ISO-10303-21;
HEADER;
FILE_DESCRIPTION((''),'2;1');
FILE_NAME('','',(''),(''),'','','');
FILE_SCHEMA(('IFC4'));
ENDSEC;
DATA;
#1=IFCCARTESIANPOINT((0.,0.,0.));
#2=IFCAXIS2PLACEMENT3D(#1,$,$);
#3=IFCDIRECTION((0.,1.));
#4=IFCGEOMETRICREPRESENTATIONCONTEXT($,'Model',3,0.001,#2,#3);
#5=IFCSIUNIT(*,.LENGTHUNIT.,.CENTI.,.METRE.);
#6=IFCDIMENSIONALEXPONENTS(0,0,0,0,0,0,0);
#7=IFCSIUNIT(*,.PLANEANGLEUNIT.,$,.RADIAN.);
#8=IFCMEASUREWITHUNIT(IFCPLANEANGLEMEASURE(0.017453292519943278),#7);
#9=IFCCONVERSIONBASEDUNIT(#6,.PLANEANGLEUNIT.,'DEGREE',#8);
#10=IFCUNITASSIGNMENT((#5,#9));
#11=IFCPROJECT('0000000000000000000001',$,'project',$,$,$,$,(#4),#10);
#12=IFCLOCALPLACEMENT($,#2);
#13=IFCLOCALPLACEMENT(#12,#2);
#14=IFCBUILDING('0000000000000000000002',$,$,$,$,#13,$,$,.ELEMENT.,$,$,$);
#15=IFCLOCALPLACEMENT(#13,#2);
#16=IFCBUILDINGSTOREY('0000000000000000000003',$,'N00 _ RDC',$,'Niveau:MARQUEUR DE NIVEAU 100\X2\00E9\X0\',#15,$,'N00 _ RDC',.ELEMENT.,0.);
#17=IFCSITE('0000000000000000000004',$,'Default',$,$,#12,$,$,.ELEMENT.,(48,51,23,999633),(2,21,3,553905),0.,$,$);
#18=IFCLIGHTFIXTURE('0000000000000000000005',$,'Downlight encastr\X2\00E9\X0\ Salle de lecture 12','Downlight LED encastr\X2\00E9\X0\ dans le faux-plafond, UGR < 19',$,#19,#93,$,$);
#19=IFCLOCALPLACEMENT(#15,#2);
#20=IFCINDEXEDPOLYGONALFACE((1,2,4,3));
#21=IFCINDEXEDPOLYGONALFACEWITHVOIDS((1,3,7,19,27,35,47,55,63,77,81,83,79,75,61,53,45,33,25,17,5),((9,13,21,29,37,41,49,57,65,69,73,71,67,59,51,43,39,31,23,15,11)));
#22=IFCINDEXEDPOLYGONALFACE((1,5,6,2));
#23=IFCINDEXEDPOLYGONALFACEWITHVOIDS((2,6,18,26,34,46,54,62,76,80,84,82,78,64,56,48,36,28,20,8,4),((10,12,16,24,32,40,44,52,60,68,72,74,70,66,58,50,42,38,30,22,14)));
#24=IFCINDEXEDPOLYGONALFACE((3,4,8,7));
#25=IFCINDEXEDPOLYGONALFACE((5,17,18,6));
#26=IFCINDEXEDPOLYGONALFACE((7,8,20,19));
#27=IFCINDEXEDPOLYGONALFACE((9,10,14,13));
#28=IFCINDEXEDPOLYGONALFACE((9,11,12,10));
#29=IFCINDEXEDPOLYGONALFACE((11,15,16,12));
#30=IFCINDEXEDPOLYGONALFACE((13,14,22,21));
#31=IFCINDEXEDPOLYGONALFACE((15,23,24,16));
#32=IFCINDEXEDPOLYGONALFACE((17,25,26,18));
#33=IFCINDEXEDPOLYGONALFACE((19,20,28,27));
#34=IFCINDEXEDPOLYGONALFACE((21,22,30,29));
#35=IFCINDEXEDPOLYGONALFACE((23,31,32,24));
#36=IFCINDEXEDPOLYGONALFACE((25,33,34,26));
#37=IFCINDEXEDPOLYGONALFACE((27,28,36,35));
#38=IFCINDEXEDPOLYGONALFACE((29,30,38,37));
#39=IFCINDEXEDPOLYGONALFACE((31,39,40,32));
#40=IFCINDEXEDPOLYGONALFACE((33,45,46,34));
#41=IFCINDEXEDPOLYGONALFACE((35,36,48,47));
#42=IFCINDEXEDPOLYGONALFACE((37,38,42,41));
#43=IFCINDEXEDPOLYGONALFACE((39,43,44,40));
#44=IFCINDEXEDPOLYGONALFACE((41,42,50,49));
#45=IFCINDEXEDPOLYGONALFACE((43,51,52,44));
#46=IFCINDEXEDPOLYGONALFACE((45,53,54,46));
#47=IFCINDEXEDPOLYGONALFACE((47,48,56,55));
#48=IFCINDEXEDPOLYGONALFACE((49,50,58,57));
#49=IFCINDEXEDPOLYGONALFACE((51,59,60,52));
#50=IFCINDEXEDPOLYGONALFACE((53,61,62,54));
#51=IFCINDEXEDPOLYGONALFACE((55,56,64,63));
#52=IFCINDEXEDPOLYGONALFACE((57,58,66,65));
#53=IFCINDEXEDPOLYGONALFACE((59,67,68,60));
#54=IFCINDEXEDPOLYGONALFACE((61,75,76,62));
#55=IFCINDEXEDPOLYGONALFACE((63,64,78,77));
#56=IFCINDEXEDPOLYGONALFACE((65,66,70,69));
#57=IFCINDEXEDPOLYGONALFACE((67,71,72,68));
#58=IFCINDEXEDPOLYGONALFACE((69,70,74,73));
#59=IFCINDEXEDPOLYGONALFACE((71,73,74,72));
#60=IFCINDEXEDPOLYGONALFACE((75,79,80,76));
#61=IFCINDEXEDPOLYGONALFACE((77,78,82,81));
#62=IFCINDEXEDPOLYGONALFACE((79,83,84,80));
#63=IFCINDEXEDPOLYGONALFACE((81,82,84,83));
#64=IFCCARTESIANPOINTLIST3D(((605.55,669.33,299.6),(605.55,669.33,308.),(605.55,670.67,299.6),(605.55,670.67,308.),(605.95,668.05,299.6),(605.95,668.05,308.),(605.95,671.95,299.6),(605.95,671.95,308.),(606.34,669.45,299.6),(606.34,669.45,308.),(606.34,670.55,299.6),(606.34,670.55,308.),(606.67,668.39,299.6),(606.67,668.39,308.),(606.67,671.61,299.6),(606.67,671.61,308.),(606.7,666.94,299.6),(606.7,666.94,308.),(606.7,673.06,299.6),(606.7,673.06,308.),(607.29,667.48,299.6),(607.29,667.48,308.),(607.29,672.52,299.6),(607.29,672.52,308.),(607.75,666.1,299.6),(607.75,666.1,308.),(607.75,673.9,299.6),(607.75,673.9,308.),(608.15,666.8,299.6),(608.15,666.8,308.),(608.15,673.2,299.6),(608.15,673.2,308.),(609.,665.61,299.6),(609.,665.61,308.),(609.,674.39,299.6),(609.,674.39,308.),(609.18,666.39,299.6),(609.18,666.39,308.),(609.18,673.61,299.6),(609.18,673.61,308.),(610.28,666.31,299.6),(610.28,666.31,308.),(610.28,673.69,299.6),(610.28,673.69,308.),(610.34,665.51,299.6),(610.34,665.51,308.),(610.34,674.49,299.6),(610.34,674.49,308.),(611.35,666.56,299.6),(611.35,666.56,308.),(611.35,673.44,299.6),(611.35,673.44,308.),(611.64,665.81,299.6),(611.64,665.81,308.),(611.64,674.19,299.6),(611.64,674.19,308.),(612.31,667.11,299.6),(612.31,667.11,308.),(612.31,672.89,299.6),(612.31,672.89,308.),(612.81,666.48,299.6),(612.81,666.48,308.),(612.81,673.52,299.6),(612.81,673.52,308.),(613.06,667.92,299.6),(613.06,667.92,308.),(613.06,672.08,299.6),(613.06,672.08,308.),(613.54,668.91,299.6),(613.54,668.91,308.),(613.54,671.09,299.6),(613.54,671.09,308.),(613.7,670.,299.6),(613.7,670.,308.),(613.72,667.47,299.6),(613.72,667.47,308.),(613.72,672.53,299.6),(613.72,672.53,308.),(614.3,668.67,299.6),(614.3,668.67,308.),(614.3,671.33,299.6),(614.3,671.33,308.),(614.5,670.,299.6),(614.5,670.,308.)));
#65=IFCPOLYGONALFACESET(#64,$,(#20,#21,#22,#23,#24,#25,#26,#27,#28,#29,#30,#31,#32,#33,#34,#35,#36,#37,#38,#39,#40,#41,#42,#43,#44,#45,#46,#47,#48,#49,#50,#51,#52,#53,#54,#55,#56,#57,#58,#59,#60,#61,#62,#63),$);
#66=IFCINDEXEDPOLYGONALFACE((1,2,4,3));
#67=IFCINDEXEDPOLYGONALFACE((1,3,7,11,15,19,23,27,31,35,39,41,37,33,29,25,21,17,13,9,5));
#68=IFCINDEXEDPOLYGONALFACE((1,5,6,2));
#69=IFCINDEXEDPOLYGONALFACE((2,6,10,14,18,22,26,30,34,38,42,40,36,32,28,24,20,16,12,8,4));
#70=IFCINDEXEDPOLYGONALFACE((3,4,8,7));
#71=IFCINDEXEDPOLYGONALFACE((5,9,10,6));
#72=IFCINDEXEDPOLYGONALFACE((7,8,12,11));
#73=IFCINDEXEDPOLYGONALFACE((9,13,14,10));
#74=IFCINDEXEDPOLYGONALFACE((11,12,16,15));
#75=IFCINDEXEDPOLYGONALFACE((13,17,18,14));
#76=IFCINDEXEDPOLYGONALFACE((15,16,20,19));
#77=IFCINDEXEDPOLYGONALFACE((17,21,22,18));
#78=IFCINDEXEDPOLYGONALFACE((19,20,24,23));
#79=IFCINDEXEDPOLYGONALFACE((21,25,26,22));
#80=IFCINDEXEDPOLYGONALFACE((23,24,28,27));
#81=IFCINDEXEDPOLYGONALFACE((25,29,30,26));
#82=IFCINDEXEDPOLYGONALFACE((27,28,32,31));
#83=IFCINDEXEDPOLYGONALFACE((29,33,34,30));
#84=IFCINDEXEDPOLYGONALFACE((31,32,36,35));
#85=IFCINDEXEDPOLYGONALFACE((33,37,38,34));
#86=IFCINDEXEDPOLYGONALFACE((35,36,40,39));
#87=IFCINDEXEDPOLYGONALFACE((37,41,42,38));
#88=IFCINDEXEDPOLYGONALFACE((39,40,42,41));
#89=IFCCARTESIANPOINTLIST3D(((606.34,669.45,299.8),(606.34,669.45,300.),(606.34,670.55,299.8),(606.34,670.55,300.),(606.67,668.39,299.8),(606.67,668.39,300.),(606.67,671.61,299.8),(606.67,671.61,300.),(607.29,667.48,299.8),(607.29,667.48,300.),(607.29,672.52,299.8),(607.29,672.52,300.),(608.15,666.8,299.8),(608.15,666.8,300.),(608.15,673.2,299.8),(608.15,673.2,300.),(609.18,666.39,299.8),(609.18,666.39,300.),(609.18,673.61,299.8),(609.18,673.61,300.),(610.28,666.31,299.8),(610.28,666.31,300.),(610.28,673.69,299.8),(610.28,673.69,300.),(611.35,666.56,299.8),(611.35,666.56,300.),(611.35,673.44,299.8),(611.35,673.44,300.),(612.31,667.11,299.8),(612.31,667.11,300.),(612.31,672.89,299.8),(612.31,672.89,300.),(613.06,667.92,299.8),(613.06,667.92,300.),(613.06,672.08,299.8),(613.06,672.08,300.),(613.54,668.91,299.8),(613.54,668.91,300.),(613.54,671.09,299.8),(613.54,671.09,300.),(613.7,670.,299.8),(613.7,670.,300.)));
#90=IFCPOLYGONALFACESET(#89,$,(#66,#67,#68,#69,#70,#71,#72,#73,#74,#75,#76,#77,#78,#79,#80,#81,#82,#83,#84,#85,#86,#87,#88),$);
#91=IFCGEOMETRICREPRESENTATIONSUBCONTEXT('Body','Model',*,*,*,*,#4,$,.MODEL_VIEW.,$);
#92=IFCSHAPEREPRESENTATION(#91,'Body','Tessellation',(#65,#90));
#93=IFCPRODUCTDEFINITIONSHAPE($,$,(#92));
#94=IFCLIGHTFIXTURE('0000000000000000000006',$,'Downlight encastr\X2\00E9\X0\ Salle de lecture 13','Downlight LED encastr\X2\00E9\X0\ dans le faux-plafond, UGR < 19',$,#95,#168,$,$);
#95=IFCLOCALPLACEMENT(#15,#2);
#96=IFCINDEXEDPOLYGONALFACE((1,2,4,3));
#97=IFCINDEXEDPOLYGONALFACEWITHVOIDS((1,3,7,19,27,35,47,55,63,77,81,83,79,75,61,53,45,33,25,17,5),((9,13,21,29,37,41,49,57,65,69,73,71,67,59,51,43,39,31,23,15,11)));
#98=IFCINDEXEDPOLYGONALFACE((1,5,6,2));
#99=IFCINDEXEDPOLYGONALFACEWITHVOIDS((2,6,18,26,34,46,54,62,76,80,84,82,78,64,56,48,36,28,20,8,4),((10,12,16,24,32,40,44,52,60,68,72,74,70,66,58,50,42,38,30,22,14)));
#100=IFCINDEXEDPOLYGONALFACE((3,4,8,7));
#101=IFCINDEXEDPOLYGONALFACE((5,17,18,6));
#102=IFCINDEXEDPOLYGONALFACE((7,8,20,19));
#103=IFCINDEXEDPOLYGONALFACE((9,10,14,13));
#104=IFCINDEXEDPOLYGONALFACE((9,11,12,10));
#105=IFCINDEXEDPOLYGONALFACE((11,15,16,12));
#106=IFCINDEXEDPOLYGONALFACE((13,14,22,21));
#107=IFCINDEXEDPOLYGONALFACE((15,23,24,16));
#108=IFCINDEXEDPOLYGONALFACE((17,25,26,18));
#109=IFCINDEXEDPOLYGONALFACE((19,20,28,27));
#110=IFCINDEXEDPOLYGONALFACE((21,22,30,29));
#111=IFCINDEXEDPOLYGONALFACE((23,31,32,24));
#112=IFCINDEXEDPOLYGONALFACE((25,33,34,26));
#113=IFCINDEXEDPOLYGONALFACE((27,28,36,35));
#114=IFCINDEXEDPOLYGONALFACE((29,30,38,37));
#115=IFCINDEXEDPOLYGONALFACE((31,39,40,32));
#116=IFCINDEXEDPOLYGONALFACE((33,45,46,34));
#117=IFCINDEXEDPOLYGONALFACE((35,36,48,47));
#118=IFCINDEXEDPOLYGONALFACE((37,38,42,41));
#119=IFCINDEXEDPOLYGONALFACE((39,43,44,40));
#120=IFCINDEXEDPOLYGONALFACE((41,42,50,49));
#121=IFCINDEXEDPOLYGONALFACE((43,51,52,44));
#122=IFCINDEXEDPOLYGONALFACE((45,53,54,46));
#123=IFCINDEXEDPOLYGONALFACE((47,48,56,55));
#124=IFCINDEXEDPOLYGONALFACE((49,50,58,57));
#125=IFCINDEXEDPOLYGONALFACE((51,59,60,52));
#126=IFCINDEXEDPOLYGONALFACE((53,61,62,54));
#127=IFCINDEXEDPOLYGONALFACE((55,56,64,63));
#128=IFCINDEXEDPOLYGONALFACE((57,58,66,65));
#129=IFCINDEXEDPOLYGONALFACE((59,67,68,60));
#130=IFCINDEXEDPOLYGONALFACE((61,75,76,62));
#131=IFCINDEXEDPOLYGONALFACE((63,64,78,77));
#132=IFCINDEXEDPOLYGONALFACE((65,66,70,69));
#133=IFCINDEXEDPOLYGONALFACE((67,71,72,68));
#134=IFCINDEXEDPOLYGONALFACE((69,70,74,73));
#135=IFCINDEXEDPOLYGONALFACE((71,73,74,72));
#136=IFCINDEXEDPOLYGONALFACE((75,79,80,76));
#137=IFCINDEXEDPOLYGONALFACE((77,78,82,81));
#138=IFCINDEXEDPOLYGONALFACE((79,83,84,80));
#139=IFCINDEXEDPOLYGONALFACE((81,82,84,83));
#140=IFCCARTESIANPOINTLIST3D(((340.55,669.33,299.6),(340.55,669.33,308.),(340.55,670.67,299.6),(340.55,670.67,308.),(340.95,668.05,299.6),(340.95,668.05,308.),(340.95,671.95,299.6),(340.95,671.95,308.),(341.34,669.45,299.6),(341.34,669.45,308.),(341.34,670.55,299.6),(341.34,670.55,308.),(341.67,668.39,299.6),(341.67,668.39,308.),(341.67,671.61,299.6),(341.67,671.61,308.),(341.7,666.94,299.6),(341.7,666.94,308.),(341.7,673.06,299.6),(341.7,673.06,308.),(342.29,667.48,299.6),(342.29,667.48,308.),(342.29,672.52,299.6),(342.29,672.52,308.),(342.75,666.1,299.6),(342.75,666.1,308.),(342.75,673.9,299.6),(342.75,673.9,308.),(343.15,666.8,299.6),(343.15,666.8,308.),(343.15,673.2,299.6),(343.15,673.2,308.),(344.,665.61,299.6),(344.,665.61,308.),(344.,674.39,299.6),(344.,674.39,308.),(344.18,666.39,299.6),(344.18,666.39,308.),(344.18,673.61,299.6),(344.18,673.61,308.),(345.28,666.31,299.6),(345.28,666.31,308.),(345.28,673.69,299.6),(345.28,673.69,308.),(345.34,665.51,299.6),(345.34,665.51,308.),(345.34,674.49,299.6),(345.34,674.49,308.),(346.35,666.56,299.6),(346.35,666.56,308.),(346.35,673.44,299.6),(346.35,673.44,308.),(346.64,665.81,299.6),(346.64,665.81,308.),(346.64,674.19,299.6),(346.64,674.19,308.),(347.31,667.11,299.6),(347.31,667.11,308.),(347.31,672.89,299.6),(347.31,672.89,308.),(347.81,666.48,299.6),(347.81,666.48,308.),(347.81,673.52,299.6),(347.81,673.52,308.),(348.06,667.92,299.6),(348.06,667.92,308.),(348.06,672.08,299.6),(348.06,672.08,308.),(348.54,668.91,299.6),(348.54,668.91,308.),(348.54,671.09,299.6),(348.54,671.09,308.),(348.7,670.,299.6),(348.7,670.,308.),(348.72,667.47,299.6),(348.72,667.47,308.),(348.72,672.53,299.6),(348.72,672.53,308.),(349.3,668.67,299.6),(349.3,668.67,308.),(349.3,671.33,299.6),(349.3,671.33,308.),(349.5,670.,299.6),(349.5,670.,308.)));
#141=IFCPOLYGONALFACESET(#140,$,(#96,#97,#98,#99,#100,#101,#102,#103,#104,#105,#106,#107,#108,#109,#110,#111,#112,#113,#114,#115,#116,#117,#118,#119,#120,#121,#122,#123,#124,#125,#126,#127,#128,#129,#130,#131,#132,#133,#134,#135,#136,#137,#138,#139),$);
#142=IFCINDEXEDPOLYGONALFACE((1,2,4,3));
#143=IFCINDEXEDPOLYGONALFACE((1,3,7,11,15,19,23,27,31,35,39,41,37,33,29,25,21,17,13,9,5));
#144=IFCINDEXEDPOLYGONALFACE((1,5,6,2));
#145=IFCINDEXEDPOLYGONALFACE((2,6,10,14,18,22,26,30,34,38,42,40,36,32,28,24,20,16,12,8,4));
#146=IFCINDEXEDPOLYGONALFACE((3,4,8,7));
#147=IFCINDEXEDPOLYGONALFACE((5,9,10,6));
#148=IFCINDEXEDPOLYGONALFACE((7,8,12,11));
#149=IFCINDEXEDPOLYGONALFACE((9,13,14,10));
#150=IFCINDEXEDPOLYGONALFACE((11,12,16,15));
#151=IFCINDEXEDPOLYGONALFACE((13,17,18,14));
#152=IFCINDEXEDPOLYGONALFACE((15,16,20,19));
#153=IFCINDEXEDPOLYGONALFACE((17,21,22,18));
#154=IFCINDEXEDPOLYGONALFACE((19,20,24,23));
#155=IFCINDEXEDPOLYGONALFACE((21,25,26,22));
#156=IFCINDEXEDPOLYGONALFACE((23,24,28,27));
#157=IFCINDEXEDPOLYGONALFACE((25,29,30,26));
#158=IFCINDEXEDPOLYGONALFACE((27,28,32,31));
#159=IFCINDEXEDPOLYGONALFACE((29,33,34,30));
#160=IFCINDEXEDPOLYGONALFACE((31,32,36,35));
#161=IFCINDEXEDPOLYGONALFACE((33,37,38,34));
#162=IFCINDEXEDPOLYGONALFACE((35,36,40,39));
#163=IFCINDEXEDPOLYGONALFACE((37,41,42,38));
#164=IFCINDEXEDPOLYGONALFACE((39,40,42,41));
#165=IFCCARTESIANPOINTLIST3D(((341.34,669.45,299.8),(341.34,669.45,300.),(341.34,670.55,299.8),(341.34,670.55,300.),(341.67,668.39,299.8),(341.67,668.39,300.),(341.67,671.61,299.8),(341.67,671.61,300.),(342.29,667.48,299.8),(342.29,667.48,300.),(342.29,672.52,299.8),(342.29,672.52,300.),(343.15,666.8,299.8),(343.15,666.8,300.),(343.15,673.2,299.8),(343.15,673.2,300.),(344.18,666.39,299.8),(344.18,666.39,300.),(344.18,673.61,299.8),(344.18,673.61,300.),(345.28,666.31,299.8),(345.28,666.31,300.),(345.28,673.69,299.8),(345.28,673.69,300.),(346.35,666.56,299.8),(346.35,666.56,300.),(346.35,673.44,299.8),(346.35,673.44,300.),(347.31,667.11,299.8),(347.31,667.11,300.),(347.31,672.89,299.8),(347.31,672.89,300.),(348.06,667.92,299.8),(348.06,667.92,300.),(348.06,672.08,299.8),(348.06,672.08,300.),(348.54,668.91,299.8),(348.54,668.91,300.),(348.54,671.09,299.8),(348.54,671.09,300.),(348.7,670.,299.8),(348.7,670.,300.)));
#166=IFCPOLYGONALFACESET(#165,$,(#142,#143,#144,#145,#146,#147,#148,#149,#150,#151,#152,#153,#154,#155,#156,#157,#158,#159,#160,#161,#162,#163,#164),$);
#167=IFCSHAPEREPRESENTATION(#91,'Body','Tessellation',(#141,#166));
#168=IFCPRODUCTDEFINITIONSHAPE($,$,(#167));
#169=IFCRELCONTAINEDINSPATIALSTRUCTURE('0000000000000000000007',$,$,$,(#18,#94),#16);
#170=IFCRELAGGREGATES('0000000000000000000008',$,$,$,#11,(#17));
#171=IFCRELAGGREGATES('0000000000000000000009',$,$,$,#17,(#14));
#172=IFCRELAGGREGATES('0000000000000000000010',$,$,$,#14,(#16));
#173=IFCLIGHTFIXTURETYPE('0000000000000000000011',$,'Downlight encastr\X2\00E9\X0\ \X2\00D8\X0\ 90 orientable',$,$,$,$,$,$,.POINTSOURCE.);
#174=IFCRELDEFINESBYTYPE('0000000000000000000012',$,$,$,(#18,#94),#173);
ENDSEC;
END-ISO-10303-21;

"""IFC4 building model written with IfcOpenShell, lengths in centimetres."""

from ifc_helpers import new_model, entity, si_unit, converted_unit, direction, frame, frame_2d, origin, origin_with_axes, place, context, subcontext, project, spatial, circle, hollow_circle, extrude, type_object, element, save


model = new_model("IFC4")

# Units and contexts
model_context = context("Model", 3, precision=0.001, world=origin(), true_north=direction((0.0, 1.0)))
body_context = subcontext(model_context, "Body", "Model", "MODEL_VIEW")
ifc_project = project(units=[si_unit("LENGTHUNIT", "METRE", prefix="CENTI"), converted_unit("PLANEANGLEUNIT", "DEGREE", entity("IfcPlaneAngleMeasure", 0.017453292519943278), si_unit("PLANEANGLEUNIT", "RADIAN"), dimensions=[0, 0, 0, 0, 0, 0, 0])], contexts=[model_context])

# Site, building, storey
site_placement = place(None, origin())
site = spatial("IfcSite", under=ifc_project, at=site_placement, Name="Default", CompositionType="ELEMENT", RefLatitude=(48, 51, 23, 999633), RefLongitude=(2, 21, 3, 553905), RefElevation=0.0)
building_placement = place(site_placement, origin())
building = spatial("IfcBuilding", under=site, at=building_placement, CompositionType="ELEMENT")
storey_placement = place(building_placement, origin())
storey = spatial("IfcBuildingStorey", under=building, at=storey_placement, Name="N00 _ RDC", ObjectType="Niveau:MARQUEUR DE NIVEAU 100é", LongName="N00 _ RDC", CompositionType="ELEMENT", Elevation=0.0)

# Light fixtures
light_fixture_type_1 = type_object("IfcLightFixtureType", Name="Downlight encastré Ø 90 orientable", PredefinedType="POINTSOURCE")
light_fixture_1_placement = place(storey_placement, origin_with_axes())
element("IfcLightFixture", 1, at=light_fixture_1_placement, inside=storey, type_object=light_fixture_type_1, Name="Downlight encastré Salle de lecture 12", Description="Downlight LED encastré dans le faux-plafond, UGR < 19", context=body_context, shape_type="SweptSolid", body=[
    extrude(hollow_circle(Radius=4.5, WallThickness=0.8, at=frame_2d((610.0, 670.0))), frame((0.0, 0.0, 299.6)), (0.0, 0.0, 1.0), 8.4),
    extrude(circle(Radius=3.7, at=frame_2d((610.0, 670.0))), frame((0.0, 0.0, 299.8)), (0.0, 0.0, 1.0), 0.2),
])
light_fixture_2_placement = place(storey_placement, origin_with_axes())
element("IfcLightFixture", 2, at=light_fixture_2_placement, inside=storey, type_object=light_fixture_type_1, Name="Downlight encastré Salle de lecture 13", Description="Downlight LED encastré dans le faux-plafond, UGR < 19", context=body_context, shape_type="SweptSolid", body=[
    extrude(hollow_circle(Radius=4.5, WallThickness=0.8, at=frame_2d((345.0, 670.0))), frame((0.0, 0.0, 299.6)), (0.0, 0.0, 1.0), 8.4),
    extrude(circle(Radius=3.7, at=frame_2d((345.0, 670.0))), frame((0.0, 0.0, 299.8)), (0.0, 0.0, 1.0), 0.2),
])

save(model, "model.ifc")
